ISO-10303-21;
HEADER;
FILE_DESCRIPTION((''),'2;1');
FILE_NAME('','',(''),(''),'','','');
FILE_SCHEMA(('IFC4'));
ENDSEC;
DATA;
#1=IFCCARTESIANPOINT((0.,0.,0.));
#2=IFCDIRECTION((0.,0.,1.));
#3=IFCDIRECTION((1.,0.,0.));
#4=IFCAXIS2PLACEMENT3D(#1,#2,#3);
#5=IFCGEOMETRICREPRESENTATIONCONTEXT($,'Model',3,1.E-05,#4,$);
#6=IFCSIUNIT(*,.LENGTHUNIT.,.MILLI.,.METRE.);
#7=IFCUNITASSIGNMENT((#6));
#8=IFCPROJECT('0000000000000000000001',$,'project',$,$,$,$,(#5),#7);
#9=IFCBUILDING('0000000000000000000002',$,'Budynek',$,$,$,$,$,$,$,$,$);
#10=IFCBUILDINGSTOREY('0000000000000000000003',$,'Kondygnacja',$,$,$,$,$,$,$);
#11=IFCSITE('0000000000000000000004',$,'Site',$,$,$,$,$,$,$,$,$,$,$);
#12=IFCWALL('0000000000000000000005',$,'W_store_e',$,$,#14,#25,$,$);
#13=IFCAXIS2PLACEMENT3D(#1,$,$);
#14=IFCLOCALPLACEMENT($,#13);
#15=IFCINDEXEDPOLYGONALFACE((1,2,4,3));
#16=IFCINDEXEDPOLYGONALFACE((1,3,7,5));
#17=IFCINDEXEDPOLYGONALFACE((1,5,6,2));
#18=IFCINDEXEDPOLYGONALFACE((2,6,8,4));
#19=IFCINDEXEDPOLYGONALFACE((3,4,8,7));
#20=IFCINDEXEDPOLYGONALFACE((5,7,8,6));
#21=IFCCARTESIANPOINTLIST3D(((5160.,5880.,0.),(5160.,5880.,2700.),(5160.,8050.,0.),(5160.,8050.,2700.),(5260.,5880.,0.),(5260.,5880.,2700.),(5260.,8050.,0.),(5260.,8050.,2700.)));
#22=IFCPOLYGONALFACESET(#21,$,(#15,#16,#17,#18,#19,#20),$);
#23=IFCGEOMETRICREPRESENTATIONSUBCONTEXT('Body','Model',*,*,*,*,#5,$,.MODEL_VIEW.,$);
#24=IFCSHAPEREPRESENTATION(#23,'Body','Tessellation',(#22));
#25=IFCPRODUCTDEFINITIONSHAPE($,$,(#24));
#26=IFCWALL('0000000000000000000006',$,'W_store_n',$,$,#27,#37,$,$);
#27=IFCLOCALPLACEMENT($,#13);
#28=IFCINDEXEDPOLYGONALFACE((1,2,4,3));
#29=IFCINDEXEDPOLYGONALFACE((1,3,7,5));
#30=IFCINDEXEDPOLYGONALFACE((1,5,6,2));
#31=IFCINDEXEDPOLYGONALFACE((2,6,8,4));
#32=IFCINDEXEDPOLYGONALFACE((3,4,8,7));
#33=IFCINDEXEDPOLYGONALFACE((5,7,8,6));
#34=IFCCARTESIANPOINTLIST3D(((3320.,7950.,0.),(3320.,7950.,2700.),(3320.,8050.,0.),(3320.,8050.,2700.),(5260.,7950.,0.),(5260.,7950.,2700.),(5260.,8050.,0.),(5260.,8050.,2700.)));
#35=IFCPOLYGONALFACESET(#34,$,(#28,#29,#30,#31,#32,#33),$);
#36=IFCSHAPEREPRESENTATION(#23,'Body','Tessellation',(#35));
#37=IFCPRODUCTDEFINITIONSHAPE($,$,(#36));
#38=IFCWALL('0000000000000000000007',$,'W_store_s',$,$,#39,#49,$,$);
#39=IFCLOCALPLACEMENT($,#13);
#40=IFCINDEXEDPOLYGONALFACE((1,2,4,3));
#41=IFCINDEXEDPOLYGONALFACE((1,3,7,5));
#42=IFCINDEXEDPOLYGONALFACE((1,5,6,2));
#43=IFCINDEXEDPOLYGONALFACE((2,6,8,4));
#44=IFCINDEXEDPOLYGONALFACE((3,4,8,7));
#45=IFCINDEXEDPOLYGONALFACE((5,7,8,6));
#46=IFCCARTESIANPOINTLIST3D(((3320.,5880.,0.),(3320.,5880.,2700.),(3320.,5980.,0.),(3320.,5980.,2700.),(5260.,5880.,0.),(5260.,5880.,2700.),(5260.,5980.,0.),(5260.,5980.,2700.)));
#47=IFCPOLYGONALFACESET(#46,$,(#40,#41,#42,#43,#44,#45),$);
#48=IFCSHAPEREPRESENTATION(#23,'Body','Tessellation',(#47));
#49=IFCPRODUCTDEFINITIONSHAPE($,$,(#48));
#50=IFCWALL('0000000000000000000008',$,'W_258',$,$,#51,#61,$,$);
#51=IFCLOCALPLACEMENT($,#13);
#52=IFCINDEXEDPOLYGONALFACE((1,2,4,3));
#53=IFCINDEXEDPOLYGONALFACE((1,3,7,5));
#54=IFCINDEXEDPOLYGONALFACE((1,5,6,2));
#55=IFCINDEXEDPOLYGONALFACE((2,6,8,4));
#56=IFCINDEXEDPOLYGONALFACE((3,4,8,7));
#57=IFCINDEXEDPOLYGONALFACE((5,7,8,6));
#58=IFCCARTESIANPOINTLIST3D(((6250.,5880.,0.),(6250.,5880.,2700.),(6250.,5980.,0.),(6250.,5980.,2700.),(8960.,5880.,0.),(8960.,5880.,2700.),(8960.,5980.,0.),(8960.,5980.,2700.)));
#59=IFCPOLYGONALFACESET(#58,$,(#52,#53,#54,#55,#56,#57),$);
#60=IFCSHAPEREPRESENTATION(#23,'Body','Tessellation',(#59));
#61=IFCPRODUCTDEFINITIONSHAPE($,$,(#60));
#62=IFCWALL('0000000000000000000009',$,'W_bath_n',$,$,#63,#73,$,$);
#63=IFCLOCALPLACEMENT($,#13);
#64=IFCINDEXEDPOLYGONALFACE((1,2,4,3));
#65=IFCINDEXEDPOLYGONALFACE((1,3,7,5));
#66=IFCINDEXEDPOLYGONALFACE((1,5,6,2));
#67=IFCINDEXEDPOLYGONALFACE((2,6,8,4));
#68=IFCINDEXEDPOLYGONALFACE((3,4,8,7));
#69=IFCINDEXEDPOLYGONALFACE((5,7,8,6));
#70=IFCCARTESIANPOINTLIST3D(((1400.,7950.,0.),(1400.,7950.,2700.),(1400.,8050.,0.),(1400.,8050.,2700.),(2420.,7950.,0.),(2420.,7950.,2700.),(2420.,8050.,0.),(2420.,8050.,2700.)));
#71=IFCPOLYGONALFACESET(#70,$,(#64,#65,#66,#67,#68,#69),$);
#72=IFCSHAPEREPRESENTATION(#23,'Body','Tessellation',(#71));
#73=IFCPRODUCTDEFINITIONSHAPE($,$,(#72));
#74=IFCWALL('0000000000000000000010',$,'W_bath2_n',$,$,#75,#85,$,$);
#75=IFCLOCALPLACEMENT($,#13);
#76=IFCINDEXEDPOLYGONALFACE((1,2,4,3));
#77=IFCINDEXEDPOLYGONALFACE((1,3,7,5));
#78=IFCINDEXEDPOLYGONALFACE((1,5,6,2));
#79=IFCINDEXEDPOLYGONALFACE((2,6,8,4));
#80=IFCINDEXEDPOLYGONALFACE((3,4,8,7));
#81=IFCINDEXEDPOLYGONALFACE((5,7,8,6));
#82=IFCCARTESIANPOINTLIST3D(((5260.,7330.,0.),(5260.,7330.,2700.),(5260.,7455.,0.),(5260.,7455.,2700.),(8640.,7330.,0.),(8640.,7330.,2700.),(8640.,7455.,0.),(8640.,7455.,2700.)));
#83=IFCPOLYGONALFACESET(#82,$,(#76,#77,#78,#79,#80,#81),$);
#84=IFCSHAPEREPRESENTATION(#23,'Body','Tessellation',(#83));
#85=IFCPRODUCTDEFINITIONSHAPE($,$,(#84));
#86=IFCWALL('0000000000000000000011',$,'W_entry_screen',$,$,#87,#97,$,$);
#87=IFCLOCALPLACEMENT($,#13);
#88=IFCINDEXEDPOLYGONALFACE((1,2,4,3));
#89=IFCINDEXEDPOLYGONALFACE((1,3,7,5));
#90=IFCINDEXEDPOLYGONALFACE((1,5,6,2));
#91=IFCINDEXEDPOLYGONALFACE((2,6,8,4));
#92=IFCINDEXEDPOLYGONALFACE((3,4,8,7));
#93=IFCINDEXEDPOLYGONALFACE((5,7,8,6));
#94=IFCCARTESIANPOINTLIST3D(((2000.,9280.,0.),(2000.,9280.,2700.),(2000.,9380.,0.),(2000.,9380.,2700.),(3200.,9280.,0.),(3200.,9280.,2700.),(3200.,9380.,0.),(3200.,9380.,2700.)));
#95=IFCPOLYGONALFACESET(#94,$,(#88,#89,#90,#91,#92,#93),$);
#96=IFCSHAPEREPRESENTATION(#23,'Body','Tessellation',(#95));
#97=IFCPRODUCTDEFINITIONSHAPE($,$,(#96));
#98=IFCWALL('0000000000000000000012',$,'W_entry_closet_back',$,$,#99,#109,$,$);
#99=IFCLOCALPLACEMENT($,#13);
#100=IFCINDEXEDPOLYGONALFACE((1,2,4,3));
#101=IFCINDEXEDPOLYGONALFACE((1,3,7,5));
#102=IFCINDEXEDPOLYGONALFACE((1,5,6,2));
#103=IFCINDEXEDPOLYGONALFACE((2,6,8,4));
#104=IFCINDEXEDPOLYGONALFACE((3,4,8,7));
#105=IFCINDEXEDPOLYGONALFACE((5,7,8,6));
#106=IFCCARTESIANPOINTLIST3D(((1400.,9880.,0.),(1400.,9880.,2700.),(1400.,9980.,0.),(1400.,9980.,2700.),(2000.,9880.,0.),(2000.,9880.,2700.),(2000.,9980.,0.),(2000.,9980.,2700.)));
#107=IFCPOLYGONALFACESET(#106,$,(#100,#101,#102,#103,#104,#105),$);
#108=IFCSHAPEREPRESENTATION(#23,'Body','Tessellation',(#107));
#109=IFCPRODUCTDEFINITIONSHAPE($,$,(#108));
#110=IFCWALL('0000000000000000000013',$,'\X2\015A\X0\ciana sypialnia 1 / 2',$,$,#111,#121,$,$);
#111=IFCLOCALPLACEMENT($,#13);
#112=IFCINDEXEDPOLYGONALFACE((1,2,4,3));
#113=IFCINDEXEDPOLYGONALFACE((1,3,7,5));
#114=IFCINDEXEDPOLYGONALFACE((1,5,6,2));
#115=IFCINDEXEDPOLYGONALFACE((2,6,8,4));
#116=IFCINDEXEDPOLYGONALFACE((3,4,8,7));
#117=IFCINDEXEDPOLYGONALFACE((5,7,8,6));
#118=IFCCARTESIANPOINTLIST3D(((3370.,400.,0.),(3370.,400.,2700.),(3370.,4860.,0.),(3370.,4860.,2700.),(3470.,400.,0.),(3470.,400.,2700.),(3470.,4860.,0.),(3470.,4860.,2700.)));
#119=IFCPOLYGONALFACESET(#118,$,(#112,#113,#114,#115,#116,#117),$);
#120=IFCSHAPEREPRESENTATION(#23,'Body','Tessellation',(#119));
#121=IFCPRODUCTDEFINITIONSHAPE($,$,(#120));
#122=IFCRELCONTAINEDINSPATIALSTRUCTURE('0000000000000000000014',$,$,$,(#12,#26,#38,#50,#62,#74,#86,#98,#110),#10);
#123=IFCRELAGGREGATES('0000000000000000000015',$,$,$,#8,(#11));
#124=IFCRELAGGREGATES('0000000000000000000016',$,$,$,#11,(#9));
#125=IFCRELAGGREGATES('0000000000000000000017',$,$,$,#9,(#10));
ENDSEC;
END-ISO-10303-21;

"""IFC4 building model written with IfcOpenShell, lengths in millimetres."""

from ifc_helpers import new_model, si_unit, frame, origin_with_axes, place, context, subcontext, project, spatial, indexed_curve, outline, extrude, element, save


model = new_model("IFC4")

# Units and contexts
model_context = context("Model", 3, precision=1e-05, world=origin_with_axes())
body_context = subcontext(model_context, "Body", "Model", "MODEL_VIEW")
ifc_project = project(units=[si_unit("LENGTHUNIT", "METRE", prefix="MILLI")], contexts=[model_context])

# Site, building, storey
site = spatial("IfcSite", under=ifc_project, Name="Site")
building = spatial("IfcBuilding", under=site, Name="Budynek")
storey = spatial("IfcBuildingStorey", under=building, Name="Kondygnacja")

# Walls
wall_1_placement = place(None, frame((5210.0, 5880.0, 0.0), z_axis=(0.0, 0.0, 1.0), x_axis=(0.0, 1.0, 0.0)))
element("IfcWall", 1, at=wall_1_placement, inside=storey, Name="W_store_e", context=body_context, shape_type="SweptSolid", body=[
    extrude(outline(indexed_curve([(0.0, 0.0), (0.0, 100.0), (2170.0, 100.0), (2170.0, 0.0), (0.0, 0.0)], self_intersect=False)), frame((0.0, -50.0, 0.0), z_axis=(0.0, 0.0, 1.0), x_axis=(1.0, 0.0, 0.0)), (0.0, 0.0, 1.0), 2700.0),
])
for number, where, z_axis, x_axis, name in (
    (2, (3320.0, 8000.0, 0.0), (0.0, 0.0, 1.0), (1.0, 0.0, 0.0), "W_store_n"),
    (3, (3320.0, 5930.0, 0.0), (0.0, 0.0, 1.0), (1.0, 0.0, 0.0), "W_store_s"),
):
    element("IfcWall", number, at=place(None, frame(where, z_axis=z_axis, x_axis=x_axis)), inside=storey, Name=name, context=body_context, shape_type="SweptSolid", body=[
        extrude(outline(indexed_curve([(0.0, 0.0), (0.0, 100.0), (1940.0, 100.0), (1940.0, 0.0), (0.0, 0.0)], self_intersect=False)), frame((0.0, -50.0, 0.0), z_axis=(0.0, 0.0, 1.0), x_axis=(1.0, 0.0, 0.0)), (0.0, 0.0, 1.0), 2700.0),
    ])
wall_2_placement = place(None, frame((6250.0, 5930.0, 0.0), z_axis=(0.0, 0.0, 1.0), x_axis=(1.0, 0.0, 0.0)))
element("IfcWall", 4, at=wall_2_placement, inside=storey, Name="W_258", context=body_context, shape_type="SweptSolid", body=[
    extrude(outline(indexed_curve([(0.0, 0.0), (0.0, 100.0), (2710.0, 100.0), (2710.0, 0.0), (0.0, 0.0)], self_intersect=False)), frame((0.0, -50.0, 0.0), z_axis=(0.0, 0.0, 1.0), x_axis=(1.0, 0.0, 0.0)), (0.0, 0.0, 1.0), 2700.0),
])
wall_3_placement = place(None, frame((1400.0, 8000.0, 0.0), z_axis=(0.0, 0.0, 1.0), x_axis=(1.0, 0.0, 0.0)))
element("IfcWall", 5, at=wall_3_placement, inside=storey, Name="W_bath_n", context=body_context, shape_type="SweptSolid", body=[
    extrude(outline(indexed_curve([(0.0, 0.0), (0.0, 100.0), (1020.0, 100.0), (1020.0, 0.0), (0.0, 0.0)], self_intersect=False)), frame((0.0, -50.0, 0.0), z_axis=(0.0, 0.0, 1.0), x_axis=(1.0, 0.0, 0.0)), (0.0, 0.0, 1.0), 2700.0),
])
wall_4_placement = place(None, frame((5260.0, 7392.5, 0.0), z_axis=(0.0, 0.0, 1.0), x_axis=(1.0, 0.0, 0.0)))
element("IfcWall", 6, at=wall_4_placement, inside=storey, Name="W_bath2_n", context=body_context, shape_type="SweptSolid", body=[
    extrude(outline(indexed_curve([(0.0, 0.0), (0.0, 125.0), (3380.0, 125.0), (3380.0, 0.0), (0.0, 0.0)], self_intersect=False)), frame((0.0, -62.5, 0.0), z_axis=(0.0, 0.0, 1.0), x_axis=(1.0, 0.0, 0.0)), (0.0, 0.0, 1.0), 2700.0),
])
wall_5_placement = place(None, frame((2000.0, 9330.0, 0.0), z_axis=(0.0, 0.0, 1.0), x_axis=(1.0, 0.0, 0.0)))
element("IfcWall", 7, at=wall_5_placement, inside=storey, Name="W_entry_screen", context=body_context, shape_type="SweptSolid", body=[
    extrude(outline(indexed_curve([(0.0, 0.0), (0.0, 100.0), (1200.0, 100.0), (1200.0, 0.0), (0.0, 0.0)], self_intersect=False)), frame((0.0, -50.0, 0.0), z_axis=(0.0, 0.0, 1.0), x_axis=(1.0, 0.0, 0.0)), (0.0, 0.0, 1.0), 2700.0),
])
wall_6_placement = place(None, frame((1400.0, 9930.0, 0.0), z_axis=(0.0, 0.0, 1.0), x_axis=(1.0, 0.0, 0.0)))
element("IfcWall", 8, at=wall_6_placement, inside=storey, Name="W_entry_closet_back", context=body_context, shape_type="SweptSolid", body=[
    extrude(outline(indexed_curve([(0.0, 0.0), (0.0, 100.0), (600.0, 100.0), (600.0, 0.0), (0.0, 0.0)], self_intersect=False)), frame((0.0, -50.0, 0.0), z_axis=(0.0, 0.0, 1.0), x_axis=(1.0, 0.0, 0.0)), (0.0, 0.0, 1.0), 2700.0),
])
wall_7_placement = place(None, frame((3420.0, 400.0, 0.0), z_axis=(0.0, 0.0, 1.0), x_axis=(0.0, 1.0, 0.0)))
element("IfcWall", 9, at=wall_7_placement, inside=storey, Name="Ściana sypialnia 1 / 2", context=body_context, shape_type="SweptSolid", body=[
    extrude(outline(indexed_curve([(0.0, 0.0), (0.0, 100.0), (4460.0, 100.0), (4460.0, 0.0), (0.0, 0.0)], self_intersect=False)), frame((0.0, -50.0, 0.0), z_axis=(0.0, 0.0, 1.0), x_axis=(1.0, 0.0, 0.0)), (0.0, 0.0, 1.0), 2700.0),
])

save(model, "model.ifc")
